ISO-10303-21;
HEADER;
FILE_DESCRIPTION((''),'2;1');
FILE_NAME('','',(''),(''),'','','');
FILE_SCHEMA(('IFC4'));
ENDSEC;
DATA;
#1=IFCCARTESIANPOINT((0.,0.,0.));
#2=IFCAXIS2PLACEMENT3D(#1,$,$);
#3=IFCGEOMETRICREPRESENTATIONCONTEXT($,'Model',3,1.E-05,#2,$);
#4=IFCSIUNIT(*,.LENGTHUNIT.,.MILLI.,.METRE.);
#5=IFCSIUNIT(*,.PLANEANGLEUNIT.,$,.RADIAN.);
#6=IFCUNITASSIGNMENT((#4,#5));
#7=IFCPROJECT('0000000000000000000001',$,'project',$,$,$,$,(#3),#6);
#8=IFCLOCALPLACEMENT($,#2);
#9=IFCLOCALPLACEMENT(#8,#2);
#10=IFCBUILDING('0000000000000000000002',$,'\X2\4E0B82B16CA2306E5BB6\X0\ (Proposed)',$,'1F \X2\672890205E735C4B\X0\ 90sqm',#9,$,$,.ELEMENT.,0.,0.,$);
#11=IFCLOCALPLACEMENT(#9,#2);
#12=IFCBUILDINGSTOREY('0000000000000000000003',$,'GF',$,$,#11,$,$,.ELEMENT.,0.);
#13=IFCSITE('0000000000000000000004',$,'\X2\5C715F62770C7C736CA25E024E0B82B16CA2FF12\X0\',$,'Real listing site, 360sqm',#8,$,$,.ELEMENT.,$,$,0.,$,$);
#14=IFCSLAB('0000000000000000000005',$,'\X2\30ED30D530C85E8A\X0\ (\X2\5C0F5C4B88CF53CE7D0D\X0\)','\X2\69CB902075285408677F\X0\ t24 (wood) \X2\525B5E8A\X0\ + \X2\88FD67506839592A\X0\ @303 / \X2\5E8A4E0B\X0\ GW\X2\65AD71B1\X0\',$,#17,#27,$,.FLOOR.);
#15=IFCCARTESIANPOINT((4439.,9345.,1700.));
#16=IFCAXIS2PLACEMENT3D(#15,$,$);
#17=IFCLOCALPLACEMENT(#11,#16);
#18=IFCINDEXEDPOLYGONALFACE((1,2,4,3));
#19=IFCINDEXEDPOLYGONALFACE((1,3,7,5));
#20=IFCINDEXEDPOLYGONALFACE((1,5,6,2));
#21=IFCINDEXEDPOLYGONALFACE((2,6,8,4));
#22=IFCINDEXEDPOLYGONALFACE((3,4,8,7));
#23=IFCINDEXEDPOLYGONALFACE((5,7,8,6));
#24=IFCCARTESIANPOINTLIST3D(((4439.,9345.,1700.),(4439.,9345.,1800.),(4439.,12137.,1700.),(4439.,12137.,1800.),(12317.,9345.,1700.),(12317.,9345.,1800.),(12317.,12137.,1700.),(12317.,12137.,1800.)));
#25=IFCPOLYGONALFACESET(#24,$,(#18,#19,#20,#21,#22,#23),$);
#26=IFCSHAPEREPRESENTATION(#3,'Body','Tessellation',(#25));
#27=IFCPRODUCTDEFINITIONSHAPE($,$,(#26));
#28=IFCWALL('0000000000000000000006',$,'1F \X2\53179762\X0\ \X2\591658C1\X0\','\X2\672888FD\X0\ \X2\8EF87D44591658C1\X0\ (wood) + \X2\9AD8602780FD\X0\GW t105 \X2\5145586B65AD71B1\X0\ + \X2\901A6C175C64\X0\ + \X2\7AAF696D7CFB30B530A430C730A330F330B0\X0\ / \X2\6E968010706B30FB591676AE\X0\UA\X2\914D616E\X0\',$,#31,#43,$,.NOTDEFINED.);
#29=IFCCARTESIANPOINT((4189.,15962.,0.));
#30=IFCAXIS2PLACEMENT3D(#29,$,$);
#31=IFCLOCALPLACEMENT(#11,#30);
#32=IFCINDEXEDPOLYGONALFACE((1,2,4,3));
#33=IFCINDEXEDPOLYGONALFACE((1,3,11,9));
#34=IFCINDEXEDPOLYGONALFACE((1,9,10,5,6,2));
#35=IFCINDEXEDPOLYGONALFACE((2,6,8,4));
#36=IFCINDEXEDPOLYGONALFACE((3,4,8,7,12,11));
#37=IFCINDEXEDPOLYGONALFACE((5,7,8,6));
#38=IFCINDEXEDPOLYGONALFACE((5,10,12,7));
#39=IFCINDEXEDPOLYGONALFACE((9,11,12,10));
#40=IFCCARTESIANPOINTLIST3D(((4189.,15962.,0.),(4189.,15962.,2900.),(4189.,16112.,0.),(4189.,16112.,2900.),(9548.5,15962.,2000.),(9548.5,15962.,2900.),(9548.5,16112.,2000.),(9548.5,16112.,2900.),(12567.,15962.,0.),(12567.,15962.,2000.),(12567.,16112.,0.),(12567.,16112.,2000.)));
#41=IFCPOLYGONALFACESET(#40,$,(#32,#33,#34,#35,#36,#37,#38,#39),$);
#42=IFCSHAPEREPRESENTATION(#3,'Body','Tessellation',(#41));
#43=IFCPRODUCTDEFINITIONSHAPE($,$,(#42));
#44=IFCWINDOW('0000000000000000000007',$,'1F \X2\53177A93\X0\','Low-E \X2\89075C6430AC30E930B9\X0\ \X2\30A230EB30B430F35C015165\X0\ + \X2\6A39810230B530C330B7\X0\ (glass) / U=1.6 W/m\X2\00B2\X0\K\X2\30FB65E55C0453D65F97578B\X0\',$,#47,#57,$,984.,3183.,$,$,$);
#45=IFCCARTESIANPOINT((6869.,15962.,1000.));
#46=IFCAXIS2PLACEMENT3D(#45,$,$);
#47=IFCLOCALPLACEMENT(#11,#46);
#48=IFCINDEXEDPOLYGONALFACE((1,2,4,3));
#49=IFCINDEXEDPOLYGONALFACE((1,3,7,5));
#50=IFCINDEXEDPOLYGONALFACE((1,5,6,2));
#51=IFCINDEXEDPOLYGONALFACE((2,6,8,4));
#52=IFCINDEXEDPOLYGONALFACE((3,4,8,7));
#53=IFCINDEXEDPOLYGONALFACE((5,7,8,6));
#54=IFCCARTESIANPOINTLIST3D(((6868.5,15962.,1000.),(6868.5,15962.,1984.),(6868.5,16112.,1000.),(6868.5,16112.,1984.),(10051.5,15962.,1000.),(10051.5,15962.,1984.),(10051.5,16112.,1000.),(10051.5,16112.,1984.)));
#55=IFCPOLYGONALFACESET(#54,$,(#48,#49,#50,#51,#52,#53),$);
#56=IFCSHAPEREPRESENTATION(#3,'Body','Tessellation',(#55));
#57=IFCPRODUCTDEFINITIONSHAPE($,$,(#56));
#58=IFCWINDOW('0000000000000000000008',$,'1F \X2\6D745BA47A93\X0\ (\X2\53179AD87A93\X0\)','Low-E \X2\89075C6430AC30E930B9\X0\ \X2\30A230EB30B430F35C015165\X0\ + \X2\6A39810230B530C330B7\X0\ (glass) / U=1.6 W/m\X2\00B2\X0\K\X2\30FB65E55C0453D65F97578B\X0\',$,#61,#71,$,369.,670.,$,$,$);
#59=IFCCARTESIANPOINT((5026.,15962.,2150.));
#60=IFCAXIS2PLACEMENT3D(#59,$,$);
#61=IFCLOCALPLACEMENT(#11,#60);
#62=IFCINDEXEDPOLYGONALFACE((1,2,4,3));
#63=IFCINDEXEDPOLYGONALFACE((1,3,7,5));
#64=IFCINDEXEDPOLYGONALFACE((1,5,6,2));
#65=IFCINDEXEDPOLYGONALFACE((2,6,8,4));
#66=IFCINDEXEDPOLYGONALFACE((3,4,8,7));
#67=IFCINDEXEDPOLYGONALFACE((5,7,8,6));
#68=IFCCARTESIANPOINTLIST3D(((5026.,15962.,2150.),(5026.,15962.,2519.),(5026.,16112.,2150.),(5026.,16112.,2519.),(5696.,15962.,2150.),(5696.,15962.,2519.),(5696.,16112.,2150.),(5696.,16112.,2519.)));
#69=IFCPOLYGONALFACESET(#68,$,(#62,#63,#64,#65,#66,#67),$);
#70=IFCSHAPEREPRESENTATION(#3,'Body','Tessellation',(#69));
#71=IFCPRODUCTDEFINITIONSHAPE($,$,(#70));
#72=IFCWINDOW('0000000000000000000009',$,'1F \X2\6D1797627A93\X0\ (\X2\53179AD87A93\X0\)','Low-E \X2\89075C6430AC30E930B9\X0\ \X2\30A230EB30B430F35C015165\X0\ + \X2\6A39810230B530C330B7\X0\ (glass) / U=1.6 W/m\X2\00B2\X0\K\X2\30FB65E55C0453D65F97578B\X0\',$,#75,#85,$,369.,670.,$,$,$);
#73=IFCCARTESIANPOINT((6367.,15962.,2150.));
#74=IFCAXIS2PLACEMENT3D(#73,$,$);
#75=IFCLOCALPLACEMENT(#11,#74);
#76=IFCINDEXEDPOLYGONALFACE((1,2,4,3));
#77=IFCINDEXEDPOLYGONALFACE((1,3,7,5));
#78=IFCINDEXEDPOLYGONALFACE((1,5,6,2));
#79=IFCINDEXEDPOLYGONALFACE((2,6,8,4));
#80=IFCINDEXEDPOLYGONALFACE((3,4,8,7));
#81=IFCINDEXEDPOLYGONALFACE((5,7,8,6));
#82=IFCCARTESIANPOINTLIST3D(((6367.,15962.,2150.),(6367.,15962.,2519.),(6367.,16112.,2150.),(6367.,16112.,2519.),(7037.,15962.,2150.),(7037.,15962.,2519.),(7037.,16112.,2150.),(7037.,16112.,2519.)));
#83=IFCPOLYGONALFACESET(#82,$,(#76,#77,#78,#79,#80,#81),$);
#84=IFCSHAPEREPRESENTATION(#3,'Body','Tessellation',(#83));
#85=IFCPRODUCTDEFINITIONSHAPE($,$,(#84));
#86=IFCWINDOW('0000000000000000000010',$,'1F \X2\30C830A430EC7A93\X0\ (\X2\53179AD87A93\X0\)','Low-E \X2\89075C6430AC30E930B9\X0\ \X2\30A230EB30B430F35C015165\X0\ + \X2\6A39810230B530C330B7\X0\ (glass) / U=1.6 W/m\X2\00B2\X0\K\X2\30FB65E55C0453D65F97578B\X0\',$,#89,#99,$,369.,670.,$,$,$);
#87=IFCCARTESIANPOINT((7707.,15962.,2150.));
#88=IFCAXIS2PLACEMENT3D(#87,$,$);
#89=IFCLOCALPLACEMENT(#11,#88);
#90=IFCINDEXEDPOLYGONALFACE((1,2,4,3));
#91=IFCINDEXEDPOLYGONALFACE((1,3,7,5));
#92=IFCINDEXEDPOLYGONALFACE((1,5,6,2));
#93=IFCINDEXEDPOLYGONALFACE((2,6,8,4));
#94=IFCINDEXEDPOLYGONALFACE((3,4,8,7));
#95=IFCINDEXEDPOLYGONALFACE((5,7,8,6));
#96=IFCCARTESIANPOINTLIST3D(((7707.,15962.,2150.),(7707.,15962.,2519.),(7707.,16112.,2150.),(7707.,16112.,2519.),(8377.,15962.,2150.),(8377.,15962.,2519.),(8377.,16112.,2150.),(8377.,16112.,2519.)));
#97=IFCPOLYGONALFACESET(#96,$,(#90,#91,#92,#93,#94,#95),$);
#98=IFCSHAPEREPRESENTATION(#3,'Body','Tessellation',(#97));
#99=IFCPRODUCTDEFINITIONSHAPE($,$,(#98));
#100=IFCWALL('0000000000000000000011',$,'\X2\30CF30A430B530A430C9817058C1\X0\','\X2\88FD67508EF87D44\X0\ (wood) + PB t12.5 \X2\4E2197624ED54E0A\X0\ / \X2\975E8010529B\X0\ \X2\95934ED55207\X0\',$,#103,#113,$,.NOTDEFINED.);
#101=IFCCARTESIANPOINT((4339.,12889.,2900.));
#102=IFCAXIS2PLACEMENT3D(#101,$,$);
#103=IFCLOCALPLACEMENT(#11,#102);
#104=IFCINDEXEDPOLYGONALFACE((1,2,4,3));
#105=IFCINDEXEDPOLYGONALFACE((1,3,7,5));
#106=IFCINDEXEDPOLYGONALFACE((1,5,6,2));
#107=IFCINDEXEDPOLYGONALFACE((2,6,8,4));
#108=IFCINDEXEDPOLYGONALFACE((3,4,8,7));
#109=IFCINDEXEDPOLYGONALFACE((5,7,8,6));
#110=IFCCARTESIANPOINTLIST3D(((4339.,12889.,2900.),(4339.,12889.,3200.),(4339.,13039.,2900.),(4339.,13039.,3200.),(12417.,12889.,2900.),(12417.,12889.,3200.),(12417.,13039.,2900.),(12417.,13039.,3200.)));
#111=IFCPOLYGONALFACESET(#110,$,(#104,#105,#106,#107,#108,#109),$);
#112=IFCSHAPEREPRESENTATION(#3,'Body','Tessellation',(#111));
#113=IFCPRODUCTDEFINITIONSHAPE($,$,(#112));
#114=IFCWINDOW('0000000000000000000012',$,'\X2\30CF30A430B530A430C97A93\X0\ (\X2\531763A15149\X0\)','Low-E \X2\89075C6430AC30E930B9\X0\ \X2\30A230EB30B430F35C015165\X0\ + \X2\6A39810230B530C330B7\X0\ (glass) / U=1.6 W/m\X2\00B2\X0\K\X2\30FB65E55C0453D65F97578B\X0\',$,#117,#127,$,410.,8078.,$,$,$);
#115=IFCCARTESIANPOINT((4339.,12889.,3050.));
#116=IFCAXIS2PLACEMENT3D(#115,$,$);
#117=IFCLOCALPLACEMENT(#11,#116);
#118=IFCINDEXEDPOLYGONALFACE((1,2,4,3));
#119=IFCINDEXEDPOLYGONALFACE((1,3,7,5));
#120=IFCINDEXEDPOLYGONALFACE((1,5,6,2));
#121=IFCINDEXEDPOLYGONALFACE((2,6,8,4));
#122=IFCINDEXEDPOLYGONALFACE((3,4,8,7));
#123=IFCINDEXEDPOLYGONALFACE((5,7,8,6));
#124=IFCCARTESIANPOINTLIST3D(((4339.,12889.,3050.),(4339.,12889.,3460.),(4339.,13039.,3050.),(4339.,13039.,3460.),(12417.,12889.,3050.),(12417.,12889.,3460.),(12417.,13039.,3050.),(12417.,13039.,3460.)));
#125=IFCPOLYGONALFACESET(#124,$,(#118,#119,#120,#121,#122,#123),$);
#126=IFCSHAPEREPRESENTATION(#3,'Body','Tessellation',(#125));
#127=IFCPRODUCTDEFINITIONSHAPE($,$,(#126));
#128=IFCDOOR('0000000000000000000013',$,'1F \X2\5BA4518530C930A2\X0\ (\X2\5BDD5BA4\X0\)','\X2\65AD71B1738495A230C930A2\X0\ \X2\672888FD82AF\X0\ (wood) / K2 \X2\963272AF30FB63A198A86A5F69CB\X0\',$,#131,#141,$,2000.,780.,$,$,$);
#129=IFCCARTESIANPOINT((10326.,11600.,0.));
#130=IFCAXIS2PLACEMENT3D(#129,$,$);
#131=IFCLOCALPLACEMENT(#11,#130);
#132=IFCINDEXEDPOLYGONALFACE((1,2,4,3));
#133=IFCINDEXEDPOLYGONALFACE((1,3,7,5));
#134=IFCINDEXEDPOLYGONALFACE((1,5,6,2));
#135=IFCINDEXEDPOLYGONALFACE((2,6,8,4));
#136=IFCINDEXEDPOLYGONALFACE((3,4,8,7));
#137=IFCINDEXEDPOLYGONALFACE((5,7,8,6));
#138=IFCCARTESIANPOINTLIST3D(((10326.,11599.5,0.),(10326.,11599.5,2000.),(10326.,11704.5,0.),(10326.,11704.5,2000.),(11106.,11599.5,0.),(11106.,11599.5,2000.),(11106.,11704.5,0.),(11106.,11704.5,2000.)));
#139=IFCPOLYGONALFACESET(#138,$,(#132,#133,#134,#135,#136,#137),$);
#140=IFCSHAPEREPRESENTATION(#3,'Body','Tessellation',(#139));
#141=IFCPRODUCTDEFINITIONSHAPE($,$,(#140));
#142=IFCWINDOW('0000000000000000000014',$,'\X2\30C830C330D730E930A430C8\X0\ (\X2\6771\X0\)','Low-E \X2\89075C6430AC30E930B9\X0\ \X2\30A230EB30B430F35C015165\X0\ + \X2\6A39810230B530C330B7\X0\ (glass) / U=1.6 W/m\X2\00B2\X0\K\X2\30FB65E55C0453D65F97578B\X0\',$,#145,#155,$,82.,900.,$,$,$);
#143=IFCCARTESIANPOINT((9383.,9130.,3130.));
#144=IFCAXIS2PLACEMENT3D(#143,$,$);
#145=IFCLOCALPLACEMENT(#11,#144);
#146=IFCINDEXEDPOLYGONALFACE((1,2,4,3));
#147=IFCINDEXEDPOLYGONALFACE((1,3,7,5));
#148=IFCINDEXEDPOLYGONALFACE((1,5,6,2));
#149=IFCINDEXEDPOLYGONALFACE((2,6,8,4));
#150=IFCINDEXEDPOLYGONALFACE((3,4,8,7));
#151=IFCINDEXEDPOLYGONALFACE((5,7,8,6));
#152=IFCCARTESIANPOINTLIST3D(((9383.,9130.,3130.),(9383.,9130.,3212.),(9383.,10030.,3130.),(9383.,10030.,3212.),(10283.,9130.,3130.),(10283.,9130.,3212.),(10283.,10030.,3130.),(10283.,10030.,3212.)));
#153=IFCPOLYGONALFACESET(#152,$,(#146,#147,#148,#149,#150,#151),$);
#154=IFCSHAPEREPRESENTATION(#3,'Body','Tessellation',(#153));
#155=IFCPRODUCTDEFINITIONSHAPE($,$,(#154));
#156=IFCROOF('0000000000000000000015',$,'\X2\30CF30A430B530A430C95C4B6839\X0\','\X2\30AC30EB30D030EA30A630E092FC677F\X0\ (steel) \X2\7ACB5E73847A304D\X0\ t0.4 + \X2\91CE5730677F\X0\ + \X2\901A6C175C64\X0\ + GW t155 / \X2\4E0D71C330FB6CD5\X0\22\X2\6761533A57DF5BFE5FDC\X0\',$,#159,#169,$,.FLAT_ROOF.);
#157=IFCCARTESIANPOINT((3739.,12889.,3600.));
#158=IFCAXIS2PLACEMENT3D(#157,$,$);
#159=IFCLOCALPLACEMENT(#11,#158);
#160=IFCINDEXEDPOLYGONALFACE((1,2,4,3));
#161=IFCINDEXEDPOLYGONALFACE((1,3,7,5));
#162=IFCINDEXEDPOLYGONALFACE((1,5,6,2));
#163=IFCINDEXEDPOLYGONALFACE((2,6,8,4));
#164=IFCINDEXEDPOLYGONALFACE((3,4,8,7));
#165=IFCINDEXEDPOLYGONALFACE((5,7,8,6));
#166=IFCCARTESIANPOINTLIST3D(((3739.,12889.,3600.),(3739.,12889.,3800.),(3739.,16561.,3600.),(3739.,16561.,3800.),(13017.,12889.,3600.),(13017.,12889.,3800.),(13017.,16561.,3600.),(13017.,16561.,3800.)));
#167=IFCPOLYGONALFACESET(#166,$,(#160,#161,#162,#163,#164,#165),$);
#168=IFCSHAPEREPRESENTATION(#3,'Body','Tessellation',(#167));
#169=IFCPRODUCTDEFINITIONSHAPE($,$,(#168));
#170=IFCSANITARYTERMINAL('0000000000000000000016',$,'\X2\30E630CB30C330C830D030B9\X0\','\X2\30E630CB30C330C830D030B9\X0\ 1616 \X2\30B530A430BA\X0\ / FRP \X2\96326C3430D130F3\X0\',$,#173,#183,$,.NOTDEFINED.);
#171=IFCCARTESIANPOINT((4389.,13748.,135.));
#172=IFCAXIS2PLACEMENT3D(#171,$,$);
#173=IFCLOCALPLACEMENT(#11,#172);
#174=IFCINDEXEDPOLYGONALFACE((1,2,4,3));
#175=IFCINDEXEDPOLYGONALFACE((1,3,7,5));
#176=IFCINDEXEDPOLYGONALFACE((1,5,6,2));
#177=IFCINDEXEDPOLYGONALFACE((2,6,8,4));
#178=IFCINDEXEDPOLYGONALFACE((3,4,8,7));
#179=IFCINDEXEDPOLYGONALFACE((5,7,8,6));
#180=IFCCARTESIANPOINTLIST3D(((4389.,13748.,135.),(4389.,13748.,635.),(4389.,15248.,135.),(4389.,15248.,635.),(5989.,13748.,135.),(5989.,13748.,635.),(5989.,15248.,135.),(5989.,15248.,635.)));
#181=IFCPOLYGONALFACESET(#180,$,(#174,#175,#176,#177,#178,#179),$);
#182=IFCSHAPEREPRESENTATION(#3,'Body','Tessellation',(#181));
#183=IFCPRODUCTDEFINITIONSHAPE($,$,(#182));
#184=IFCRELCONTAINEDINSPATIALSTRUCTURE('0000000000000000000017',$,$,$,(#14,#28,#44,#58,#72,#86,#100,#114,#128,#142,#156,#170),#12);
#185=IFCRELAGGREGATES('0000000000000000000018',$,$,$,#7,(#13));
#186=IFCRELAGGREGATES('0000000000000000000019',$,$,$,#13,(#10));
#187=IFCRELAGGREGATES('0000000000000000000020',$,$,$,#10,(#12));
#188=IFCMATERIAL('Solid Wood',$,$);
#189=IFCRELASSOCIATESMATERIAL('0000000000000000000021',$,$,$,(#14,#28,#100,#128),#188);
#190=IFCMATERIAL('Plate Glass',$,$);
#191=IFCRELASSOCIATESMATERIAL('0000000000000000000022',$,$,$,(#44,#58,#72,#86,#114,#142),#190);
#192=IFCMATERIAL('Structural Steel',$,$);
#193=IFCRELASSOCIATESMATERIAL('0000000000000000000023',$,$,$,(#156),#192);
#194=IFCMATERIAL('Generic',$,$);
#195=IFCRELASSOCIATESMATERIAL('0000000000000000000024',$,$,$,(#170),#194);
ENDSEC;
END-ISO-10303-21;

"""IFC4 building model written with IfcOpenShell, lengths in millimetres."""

from ifc_helpers import new_model, si_unit, frame, frame_2d, origin, place, context, project, spatial, rectangle, extrude, material, element, fill, save


model = new_model("IFC4")

# Units and contexts
model_context = context("Model", 3, precision=1e-05, world=origin())
ifc_project = project(units=[si_unit("LENGTHUNIT", "METRE", prefix="MILLI"), si_unit("PLANEANGLEUNIT", "RADIAN")], contexts=[model_context])

# Site, building, storey
site_placement = place(None, origin())
site = spatial("IfcSite", under=ifc_project, at=site_placement, Name="山形県米沢市下花沢２", ObjectType="Real listing site, 360sqm", CompositionType="ELEMENT", RefElevation=0.0)
building_placement = place(site_placement, origin())
building = spatial("IfcBuilding", under=site, at=building_placement, Name="下花沢の家 (Proposed)", ObjectType="1F 木造平屋 90sqm", CompositionType="ELEMENT", ElevationOfRefHeight=0.0, ElevationOfTerrain=0.0)
storey_placement = place(building_placement, origin())
storey = spatial("IfcBuildingStorey", under=building, at=storey_placement, Name="GF", CompositionType="ELEMENT", Elevation=0.0)

# Slab
ifc_material_1 = material(Name="Solid Wood")
slab_placement = place(storey_placement, frame((4439.0, 9345.0, 1700.0)))
element("IfcSlab", 1, at=slab_placement, inside=storey, material=ifc_material_1, Name="ロフト床 (小屋裏収納)", Description="構造用合板 t24 (wood) 剛床 + 製材根太 @303 / 床下 GW断熱", PredefinedType="FLOOR", context=model_context, shape_type="SweptSolid", body=[
    extrude(rectangle(XDim=7878.0, YDim=2792.0, at=frame_2d((3939.0, 1396.0))), frame((4439.0, 9345.0, 1700.0)), (0.0, 0.0, 1.0), 100.0),
])

# Wall, openings, windows
wall_1_placement = place(storey_placement, frame((4189.0, 15962.0, 0.0)))
wall_1 = element("IfcWall", 2, at=wall_1_placement, inside=storey, material=ifc_material_1, Name="1F 北面 外壁", Description="木製 軸組外壁 (wood) + 高性能GW t105 充填断熱 + 通気層 + 窯業系サイディング / 準耐火・外皮UA配慮", PredefinedType="NOTDEFINED", context=model_context, shape_type="SweptSolid", body=[
    extrude(rectangle(XDim=8378.0, YDim=150.0, at=frame_2d((4189.0, 75.0))), frame((4189.0, 15962.0, 0.0)), (0.0, 0.0, 1.0), 2900.0),
])
opening_1_placement = place(storey_placement, frame((6869.0, 15962.0, 1000.0)))
opening_1 = element("IfcOpeningElement", 3, at=opening_1_placement, cuts=wall_1, PredefinedType="NOTDEFINED", context=model_context, shape_type="SweptSolid", body=[
    extrude(rectangle(XDim=3183.0, YDim=150.0, at=frame_2d((1591.0, 75.0))), frame((6869.0, 15962.0, 1000.0)), (0.0, 0.0, 1.0), 984.0),
])
opening_2_placement = place(storey_placement, frame((5026.0, 15962.0, 2150.0)))
opening_2 = element("IfcOpeningElement", 4, at=opening_2_placement, cuts=wall_1, PredefinedType="NOTDEFINED", context=model_context, shape_type="SweptSolid", body=[
    extrude(rectangle(XDim=670.0, YDim=150.0, at=frame_2d((335.0, 75.0))), frame((5026.0, 15962.0, 2150.0)), (0.0, 0.0, 1.0), 369.0),
])
opening_3_placement = place(storey_placement, frame((6367.0, 15962.0, 2150.0)))
opening_3 = element("IfcOpeningElement", 5, at=opening_3_placement, cuts=wall_1, PredefinedType="NOTDEFINED", context=model_context, shape_type="SweptSolid", body=[
    extrude(rectangle(XDim=670.0, YDim=150.0, at=frame_2d((335.0, 75.0))), frame((6367.0, 15962.0, 2150.0)), (0.0, 0.0, 1.0), 369.0),
])
opening_4_placement = place(storey_placement, frame((7707.0, 15962.0, 2150.0)))
opening_4 = element("IfcOpeningElement", 6, at=opening_4_placement, cuts=wall_1, PredefinedType="NOTDEFINED", context=model_context, shape_type="SweptSolid", body=[
    extrude(rectangle(XDim=670.0, YDim=150.0, at=frame_2d((335.0, 75.0))), frame((7707.0, 15962.0, 2150.0)), (0.0, 0.0, 1.0), 369.0),
])
ifc_material_2 = material(Name="Plate Glass")
window_1_placement = place(storey_placement, frame((6869.0, 15962.0, 1000.0)))
window_1 = element("IfcWindow", 7, at=window_1_placement, inside=storey, material=ifc_material_2, Name="1F 北窓", Description="Low-E 複層ガラス アルゴン封入 + 樹脂サッシ (glass) / U=1.6 W/m²K・日射取得型", OverallHeight=984.0, OverallWidth=3183.0, context=model_context, shape_type="SweptSolid", body=[
    extrude(rectangle(XDim=3183.0, YDim=150.0, at=frame_2d((1591.0, 75.0))), frame((6869.0, 15962.0, 1000.0)), (0.0, 0.0, 1.0), 984.0),
])
fill(opening_1, window_1)
window_2_placement = place(storey_placement, frame((5026.0, 15962.0, 2150.0)))
window_2 = element("IfcWindow", 8, at=window_2_placement, inside=storey, material=ifc_material_2, Name="1F 浴室窓 (北高窓)", Description="Low-E 複層ガラス アルゴン封入 + 樹脂サッシ (glass) / U=1.6 W/m²K・日射取得型", OverallHeight=369.0, OverallWidth=670.0, context=model_context, shape_type="SweptSolid", body=[
    extrude(rectangle(XDim=670.0, YDim=150.0, at=frame_2d((335.0, 75.0))), frame((5026.0, 15962.0, 2150.0)), (0.0, 0.0, 1.0), 369.0),
])
fill(opening_2, window_2)
window_3_placement = place(storey_placement, frame((6367.0, 15962.0, 2150.0)))
window_3 = element("IfcWindow", 9, at=window_3_placement, inside=storey, material=ifc_material_2, Name="1F 洗面窓 (北高窓)", Description="Low-E 複層ガラス アルゴン封入 + 樹脂サッシ (glass) / U=1.6 W/m²K・日射取得型", OverallHeight=369.0, OverallWidth=670.0, context=model_context, shape_type="SweptSolid", body=[
    extrude(rectangle(XDim=670.0, YDim=150.0, at=frame_2d((335.0, 75.0))), frame((6367.0, 15962.0, 2150.0)), (0.0, 0.0, 1.0), 369.0),
])
fill(opening_3, window_3)
window_4_placement = place(storey_placement, frame((7707.0, 15962.0, 2150.0)))
window_4 = element("IfcWindow", 10, at=window_4_placement, inside=storey, material=ifc_material_2, Name="1F トイレ窓 (北高窓)", Description="Low-E 複層ガラス アルゴン封入 + 樹脂サッシ (glass) / U=1.6 W/m²K・日射取得型", OverallHeight=369.0, OverallWidth=670.0, context=model_context, shape_type="SweptSolid", body=[
    extrude(rectangle(XDim=670.0, YDim=150.0, at=frame_2d((335.0, 75.0))), frame((7707.0, 15962.0, 2150.0)), (0.0, 0.0, 1.0), 369.0),
])
fill(opening_4, window_4)

# Wall, opening, window
wall_2_placement = place(storey_placement, frame((4339.0, 12889.0, 2900.0)))
wall_2 = element("IfcWall", 11, at=wall_2_placement, inside=storey, material=ifc_material_1, Name="ハイサイド腰壁", Description="製材軸組 (wood) + PB t12.5 両面仕上 / 非耐力 間仕切", PredefinedType="NOTDEFINED", context=model_context, shape_type="SweptSolid", body=[
    extrude(rectangle(XDim=8078.0, YDim=150.0, at=frame_2d((4039.0, 75.0))), frame((4339.0, 12889.0, 2900.0)), (0.0, 0.0, 1.0), 700.0),
])
opening_5_placement = place(storey_placement, frame((4339.0, 12889.0, 3050.0)))
opening_5 = element("IfcOpeningElement", 12, at=opening_5_placement, cuts=wall_2, PredefinedType="NOTDEFINED", context=model_context, shape_type="SweptSolid", body=[
    extrude(rectangle(XDim=8078.0, YDim=150.0, at=frame_2d((4039.0, 75.0))), frame((4339.0, 12889.0, 3050.0)), (0.0, 0.0, 1.0), 410.0),
])
window_5_placement = place(storey_placement, frame((4339.0, 12889.0, 3050.0)))
window_5 = element("IfcWindow", 13, at=window_5_placement, inside=storey, material=ifc_material_2, Name="ハイサイド窓 (北採光)", Description="Low-E 複層ガラス アルゴン封入 + 樹脂サッシ (glass) / U=1.6 W/m²K・日射取得型", OverallHeight=410.0, OverallWidth=8078.0, context=model_context, shape_type="SweptSolid", body=[
    extrude(rectangle(XDim=8078.0, YDim=150.0, at=frame_2d((4039.0, 75.0))), frame((4339.0, 12889.0, 3050.0)), (0.0, 0.0, 1.0), 410.0),
])
fill(opening_5, window_5)

# Door
door_1_placement = place(storey_placement, frame((10326.0, 11600.0, 0.0)))
element("IfcDoor", 14, at=door_1_placement, inside=storey, material=ifc_material_1, Name="1F 室内ドア (寝室)", Description="断熱玄関ドア 木製芯 (wood) / K2 防犯・採風機構", OverallHeight=2000.0, OverallWidth=780.0, context=model_context, shape_type="SweptSolid", body=[
    extrude(rectangle(XDim=780.0, YDim=105.0, at=frame_2d((390.0, 52.0))), frame((10326.0, 11600.0, 0.0)), (0.0, 0.0, 1.0), 2000.0),
])

# Window
window_6_placement = place(storey_placement, frame((9383.0, 9130.0, 3130.0)))
element("IfcWindow", 15, at=window_6_placement, inside=storey, material=ifc_material_2, Name="トップライト (東)", Description="Low-E 複層ガラス アルゴン封入 + 樹脂サッシ (glass) / U=1.6 W/m²K・日射取得型", OverallHeight=82.0, OverallWidth=900.0, context=model_context, shape_type="SweptSolid", body=[
    extrude(rectangle(XDim=900.0, YDim=900.0, at=frame_2d((450.0, 450.0))), frame((9383.0, 9130.0, 3130.0)), (0.0, 0.0, 1.0), 82.0),
])

# Roof
ifc_material_3 = material(Name="Structural Steel")
roof_placement = place(storey_placement, frame((3739.0, 12889.0, 3600.0)))
element("IfcRoof", 16, at=roof_placement, inside=storey, material=ifc_material_3, Name="ハイサイド屋根", Description="ガルバリウム鋼板 (steel) 立平葺き t0.4 + 野地板 + 通気層 + GW t155 / 不燃・法22条区域対応", PredefinedType="FLAT_ROOF", context=model_context, shape_type="SweptSolid", body=[
    extrude(rectangle(XDim=9278.0, YDim=3672.0, at=frame_2d((4639.0, 1836.0))), frame((3739.0, 12889.0, 3600.0)), (0.0, 0.0, 1.0), 200.0),
])

# Sanitary terminal
ifc_material_4 = material(Name="Generic")
sanitary_terminal_1_placement = place(storey_placement, frame((4389.0, 13748.0, 135.0)))
element("IfcSanitaryTerminal", 17, at=sanitary_terminal_1_placement, inside=storey, material=ifc_material_4, Name="ユニットバス", Description="ユニットバス 1616 サイズ / FRP 防水パン", PredefinedType="NOTDEFINED", context=model_context, shape_type="SweptSolid", body=[
    extrude(rectangle(XDim=1600.0, YDim=1500.0, at=frame_2d((800.0, 750.0))), frame((4389.0, 13748.0, 135.0)), (0.0, 0.0, 1.0), 500.0),
])

save(model, "model.ifc")
